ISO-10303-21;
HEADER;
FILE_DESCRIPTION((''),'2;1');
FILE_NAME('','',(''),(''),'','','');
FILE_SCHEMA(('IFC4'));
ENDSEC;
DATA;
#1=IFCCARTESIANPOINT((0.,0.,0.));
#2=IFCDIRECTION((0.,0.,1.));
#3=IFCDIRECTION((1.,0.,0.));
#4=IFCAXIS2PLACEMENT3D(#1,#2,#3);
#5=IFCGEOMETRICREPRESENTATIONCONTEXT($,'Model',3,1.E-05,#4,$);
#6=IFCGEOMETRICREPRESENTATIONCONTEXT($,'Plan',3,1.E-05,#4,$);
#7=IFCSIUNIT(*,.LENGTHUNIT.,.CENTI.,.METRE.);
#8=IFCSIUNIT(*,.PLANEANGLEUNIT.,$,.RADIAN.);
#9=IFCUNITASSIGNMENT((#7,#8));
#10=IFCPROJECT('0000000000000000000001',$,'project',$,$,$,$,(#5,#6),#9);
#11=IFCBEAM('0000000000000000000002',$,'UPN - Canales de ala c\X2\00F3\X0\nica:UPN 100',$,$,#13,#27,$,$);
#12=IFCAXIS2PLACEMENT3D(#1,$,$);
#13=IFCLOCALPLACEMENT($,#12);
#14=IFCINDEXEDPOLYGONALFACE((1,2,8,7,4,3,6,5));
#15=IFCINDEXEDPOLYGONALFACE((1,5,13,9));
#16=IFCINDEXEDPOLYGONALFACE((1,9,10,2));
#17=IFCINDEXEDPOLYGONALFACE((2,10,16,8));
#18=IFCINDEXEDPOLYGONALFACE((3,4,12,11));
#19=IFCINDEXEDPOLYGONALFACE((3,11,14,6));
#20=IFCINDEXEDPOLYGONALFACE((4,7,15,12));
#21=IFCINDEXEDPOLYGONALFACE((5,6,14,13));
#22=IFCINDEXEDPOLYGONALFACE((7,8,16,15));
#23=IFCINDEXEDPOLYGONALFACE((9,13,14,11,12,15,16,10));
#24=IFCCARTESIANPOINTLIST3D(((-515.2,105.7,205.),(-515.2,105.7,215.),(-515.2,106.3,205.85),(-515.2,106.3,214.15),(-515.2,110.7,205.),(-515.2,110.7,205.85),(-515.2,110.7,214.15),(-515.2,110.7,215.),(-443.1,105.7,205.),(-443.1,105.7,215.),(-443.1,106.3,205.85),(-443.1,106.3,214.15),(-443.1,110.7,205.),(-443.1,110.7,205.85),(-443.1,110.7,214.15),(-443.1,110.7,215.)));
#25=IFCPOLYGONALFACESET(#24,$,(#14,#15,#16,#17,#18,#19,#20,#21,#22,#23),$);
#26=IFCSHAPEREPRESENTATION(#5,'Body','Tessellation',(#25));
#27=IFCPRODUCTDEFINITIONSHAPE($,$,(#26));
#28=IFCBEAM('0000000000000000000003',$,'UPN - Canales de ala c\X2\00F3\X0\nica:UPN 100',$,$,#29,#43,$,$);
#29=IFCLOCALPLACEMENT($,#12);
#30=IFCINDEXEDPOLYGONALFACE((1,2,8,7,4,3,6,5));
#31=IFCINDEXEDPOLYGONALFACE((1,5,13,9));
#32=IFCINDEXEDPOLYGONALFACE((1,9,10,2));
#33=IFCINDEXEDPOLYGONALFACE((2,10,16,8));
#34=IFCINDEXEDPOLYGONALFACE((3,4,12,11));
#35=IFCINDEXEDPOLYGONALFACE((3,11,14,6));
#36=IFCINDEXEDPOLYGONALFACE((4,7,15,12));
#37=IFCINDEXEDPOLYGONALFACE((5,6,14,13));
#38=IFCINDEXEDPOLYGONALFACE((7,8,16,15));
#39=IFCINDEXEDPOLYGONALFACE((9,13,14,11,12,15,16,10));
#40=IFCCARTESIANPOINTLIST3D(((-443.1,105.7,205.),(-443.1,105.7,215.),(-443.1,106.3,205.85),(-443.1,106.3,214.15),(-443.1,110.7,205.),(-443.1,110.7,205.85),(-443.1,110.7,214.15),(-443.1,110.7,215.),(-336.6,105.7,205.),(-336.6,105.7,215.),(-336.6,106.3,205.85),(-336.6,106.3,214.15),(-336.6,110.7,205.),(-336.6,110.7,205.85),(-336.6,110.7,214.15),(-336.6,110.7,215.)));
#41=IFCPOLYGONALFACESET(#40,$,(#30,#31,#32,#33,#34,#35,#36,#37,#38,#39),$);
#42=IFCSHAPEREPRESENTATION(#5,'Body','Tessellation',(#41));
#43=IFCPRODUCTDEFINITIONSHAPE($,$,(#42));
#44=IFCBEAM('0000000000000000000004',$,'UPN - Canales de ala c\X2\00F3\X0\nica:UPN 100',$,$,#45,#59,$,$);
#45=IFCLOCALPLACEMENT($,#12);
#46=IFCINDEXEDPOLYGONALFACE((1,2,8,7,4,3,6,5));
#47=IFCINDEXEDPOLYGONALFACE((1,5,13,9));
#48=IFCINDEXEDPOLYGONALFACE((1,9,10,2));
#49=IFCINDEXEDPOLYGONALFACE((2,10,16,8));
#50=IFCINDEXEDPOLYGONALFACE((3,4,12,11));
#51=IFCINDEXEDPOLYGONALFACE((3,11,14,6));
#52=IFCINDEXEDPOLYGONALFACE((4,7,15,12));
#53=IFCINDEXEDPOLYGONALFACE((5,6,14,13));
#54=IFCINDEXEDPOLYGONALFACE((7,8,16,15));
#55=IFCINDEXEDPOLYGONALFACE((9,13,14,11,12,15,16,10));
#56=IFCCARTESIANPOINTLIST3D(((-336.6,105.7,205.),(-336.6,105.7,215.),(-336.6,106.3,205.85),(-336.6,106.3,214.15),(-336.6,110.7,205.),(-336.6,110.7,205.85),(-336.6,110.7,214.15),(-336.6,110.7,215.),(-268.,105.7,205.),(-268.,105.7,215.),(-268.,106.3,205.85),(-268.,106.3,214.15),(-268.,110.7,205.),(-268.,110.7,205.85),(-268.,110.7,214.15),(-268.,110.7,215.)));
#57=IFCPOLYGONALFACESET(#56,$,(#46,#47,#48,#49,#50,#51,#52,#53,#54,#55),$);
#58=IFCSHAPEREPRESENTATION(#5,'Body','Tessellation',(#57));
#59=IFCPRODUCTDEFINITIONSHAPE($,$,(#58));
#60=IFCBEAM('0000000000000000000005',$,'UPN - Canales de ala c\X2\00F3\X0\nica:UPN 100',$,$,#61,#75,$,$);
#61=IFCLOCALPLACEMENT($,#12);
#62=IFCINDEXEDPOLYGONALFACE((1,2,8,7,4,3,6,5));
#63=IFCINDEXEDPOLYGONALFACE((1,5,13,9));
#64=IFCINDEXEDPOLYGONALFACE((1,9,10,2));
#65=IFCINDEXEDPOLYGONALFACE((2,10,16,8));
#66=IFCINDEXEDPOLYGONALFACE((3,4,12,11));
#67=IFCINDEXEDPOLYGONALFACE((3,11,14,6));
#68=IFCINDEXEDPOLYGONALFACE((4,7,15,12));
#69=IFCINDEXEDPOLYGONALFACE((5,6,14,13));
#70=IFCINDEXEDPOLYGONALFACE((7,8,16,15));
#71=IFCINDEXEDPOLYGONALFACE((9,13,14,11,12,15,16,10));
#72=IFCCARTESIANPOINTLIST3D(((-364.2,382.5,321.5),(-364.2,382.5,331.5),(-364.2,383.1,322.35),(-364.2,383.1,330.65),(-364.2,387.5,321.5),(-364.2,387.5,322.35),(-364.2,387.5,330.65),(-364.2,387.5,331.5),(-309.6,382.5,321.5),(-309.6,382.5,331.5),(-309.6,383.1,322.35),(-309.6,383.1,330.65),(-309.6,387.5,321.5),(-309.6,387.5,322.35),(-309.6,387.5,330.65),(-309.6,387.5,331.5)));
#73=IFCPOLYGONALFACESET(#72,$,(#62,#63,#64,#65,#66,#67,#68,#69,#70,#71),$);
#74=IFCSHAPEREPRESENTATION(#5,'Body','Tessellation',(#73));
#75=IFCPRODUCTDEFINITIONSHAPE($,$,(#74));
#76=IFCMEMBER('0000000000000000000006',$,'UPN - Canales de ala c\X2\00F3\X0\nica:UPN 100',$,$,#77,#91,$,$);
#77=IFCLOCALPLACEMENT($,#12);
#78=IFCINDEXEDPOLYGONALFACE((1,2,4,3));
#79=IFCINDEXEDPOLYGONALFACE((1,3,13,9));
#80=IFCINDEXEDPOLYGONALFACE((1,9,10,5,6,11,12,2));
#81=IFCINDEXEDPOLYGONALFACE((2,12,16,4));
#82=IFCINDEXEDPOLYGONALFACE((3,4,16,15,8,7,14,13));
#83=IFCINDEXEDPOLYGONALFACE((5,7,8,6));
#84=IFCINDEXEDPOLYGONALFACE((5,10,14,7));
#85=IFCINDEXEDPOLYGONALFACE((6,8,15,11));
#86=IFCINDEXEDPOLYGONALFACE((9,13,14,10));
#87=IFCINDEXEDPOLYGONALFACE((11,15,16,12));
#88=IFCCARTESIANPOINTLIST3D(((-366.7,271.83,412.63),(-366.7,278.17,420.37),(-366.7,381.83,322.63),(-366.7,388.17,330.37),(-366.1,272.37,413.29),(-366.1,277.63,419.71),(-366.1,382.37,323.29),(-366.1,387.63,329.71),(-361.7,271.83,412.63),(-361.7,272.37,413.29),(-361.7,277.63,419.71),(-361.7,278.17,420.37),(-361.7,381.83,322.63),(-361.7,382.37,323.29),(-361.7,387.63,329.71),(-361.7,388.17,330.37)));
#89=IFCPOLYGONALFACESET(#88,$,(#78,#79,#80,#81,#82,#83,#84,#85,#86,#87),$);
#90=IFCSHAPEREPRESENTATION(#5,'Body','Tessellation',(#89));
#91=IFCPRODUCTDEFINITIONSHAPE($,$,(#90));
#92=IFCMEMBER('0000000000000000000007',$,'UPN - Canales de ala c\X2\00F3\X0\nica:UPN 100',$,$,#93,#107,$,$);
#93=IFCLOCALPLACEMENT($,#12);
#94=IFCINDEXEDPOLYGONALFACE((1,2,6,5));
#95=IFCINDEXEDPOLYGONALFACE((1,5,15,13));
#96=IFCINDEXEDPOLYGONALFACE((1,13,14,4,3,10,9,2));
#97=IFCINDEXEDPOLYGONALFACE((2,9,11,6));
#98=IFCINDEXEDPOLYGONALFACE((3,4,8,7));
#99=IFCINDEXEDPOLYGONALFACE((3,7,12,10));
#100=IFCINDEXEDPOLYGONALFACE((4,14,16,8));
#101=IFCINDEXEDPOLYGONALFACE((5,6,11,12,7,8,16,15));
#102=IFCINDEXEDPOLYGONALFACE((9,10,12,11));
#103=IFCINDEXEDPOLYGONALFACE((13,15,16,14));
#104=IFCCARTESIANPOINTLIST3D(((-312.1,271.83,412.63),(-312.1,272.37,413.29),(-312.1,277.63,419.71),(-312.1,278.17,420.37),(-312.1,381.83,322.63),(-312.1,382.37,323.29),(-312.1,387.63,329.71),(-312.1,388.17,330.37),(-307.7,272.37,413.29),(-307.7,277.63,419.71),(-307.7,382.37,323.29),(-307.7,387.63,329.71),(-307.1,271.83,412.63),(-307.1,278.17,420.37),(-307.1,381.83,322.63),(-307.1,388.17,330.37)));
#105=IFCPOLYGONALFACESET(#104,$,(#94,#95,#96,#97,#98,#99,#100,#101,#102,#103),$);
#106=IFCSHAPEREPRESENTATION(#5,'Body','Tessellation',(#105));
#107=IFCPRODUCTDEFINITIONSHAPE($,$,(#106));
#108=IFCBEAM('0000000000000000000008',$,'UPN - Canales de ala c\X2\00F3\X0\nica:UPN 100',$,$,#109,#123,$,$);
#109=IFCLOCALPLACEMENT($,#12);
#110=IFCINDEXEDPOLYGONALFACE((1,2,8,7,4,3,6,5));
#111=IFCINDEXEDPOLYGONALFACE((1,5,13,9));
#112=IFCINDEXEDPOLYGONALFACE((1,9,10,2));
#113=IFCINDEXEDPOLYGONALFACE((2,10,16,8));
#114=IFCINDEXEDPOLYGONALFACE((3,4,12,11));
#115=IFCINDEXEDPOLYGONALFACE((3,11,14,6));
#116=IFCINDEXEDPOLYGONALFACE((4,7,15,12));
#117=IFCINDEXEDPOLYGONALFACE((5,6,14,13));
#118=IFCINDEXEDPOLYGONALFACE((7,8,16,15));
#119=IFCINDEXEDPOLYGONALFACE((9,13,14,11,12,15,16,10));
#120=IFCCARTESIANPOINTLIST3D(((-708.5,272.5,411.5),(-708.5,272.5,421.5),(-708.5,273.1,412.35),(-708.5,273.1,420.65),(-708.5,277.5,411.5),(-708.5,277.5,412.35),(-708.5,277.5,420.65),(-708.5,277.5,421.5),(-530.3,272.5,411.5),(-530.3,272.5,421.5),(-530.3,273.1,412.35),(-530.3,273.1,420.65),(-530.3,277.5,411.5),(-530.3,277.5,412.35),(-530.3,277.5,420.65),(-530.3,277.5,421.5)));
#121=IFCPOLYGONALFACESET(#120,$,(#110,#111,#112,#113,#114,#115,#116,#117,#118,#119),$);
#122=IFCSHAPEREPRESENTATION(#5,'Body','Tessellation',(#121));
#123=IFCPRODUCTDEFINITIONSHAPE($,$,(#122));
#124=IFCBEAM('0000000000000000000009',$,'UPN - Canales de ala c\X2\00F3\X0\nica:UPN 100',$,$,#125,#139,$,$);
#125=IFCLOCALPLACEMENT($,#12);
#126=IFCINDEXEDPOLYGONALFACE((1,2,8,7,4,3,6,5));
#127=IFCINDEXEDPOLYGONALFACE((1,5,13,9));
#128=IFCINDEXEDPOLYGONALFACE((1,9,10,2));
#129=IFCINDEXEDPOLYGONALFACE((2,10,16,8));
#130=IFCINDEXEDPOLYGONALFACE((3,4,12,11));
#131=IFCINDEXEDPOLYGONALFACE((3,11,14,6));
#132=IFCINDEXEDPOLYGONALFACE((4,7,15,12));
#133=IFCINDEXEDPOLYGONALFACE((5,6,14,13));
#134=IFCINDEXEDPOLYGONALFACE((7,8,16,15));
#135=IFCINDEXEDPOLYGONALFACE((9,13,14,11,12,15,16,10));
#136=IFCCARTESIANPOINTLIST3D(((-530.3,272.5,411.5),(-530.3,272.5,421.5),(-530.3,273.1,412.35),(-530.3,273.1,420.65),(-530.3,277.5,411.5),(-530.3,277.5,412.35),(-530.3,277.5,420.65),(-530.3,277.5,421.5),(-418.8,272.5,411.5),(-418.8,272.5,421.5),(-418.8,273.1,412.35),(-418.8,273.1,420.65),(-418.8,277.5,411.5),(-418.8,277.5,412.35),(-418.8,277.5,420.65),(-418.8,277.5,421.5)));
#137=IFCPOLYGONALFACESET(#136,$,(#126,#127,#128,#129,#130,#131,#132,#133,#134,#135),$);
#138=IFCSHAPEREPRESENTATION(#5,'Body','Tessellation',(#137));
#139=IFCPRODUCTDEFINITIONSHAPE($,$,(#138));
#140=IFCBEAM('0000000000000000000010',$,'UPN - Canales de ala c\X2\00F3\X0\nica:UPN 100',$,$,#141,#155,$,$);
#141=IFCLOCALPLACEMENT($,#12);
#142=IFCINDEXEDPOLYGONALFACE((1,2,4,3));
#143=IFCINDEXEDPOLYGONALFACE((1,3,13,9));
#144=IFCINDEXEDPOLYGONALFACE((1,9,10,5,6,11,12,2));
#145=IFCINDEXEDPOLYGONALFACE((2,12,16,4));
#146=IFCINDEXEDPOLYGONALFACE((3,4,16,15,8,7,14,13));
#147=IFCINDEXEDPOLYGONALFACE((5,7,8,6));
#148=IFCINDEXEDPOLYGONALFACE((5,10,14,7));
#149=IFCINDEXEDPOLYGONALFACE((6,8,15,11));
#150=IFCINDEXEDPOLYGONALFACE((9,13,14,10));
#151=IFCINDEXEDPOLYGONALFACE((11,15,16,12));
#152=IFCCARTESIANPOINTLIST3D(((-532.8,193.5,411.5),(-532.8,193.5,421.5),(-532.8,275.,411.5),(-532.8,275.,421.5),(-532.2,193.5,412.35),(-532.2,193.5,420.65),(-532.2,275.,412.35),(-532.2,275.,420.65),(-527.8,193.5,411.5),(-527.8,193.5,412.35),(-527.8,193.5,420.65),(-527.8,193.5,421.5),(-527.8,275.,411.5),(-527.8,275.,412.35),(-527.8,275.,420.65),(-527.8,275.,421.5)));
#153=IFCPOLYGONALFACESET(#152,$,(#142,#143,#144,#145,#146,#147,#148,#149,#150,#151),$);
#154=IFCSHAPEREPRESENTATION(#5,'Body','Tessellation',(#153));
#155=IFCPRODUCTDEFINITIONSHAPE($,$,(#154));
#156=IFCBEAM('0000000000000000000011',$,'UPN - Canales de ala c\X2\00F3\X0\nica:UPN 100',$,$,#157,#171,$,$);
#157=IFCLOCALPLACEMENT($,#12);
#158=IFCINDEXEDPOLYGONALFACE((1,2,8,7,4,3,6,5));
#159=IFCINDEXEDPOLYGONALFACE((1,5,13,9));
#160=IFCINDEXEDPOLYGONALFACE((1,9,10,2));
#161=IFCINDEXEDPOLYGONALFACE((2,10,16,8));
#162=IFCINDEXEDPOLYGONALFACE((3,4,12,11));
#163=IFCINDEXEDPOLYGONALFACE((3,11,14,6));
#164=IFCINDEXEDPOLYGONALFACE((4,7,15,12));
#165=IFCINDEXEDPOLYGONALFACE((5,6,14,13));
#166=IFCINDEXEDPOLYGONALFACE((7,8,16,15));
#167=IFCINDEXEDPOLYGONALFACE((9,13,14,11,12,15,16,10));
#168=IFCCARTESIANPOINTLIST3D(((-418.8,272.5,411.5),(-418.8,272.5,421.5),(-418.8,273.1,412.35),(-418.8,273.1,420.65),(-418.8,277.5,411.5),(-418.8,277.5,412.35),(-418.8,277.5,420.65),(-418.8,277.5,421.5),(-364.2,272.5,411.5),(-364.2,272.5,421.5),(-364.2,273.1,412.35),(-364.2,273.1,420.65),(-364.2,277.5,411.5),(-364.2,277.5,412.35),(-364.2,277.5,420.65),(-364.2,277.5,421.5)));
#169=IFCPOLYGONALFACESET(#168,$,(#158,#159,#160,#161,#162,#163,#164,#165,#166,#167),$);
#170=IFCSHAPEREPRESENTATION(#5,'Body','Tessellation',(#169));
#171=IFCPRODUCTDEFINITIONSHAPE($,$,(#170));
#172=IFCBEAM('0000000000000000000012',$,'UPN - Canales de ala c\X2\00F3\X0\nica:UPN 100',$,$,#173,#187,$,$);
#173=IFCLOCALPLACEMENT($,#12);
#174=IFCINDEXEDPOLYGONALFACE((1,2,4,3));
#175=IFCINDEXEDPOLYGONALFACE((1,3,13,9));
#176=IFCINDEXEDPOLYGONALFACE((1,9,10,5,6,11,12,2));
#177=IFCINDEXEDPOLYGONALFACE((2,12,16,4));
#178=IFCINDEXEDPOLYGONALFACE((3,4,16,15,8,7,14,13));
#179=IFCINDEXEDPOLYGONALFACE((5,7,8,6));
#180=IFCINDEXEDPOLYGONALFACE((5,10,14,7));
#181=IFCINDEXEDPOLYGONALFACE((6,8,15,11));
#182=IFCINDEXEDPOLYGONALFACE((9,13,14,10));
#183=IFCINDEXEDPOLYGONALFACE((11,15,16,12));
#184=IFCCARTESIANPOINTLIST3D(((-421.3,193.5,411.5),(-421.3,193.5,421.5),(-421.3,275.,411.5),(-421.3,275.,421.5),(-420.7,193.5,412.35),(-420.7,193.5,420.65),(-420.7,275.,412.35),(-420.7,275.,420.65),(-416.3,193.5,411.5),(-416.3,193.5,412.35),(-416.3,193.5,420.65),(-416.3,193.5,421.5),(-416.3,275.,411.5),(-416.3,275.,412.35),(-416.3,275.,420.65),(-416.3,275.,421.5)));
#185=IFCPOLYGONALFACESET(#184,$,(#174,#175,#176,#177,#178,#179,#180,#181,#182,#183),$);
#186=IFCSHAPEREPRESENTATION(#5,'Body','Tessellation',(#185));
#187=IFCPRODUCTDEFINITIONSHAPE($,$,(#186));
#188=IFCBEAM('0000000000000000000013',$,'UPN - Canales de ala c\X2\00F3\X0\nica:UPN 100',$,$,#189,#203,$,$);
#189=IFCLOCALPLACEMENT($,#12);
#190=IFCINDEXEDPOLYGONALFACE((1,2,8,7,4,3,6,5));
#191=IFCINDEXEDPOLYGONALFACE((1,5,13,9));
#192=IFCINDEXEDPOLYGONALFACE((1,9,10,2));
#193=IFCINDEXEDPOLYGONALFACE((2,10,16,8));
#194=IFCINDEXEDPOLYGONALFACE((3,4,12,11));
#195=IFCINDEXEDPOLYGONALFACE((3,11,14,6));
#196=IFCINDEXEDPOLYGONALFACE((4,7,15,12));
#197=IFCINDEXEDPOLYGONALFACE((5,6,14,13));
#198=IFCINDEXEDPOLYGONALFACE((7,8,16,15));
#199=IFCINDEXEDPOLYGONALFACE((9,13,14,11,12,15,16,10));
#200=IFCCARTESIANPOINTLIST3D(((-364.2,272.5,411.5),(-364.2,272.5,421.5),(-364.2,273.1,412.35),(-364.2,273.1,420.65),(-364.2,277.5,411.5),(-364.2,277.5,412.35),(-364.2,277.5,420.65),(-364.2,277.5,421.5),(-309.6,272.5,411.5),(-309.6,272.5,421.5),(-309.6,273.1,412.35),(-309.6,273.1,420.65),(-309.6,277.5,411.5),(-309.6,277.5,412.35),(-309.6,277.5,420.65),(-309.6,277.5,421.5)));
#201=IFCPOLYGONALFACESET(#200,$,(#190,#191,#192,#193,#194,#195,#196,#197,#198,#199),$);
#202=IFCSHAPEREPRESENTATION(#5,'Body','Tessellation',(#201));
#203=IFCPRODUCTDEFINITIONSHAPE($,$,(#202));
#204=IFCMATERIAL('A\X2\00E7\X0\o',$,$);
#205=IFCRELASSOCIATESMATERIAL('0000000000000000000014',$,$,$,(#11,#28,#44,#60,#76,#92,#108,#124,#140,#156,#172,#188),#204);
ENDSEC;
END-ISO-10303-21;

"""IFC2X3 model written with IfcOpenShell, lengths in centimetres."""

from ifc_helpers import new_model, si_unit, frame, origin_with_axes, origin_2d_with_axis, place, context, project, u_section, extrude, material, element, save


model = new_model("IFC2X3")

# Units and contexts
model_context = context("Model", 3, precision=1e-05, world=origin_with_axes())
plan_context = context("Plan", 3, precision=1e-05, world=origin_with_axes())
ifc_project = project(units=[si_unit("LENGTHUNIT", "METRE", prefix="CENTI"), si_unit("PLANEANGLEUNIT", "RADIAN")], contexts=[model_context, plan_context])

# Shared definitions
ifc_material = material(Name="Aço")

# Beams
beam_1_placement = place(None, frame((-443.1, 108.2, 210.0), z_axis=(-1.0, 0.0, 0.0), x_axis=(0.0, 1.0, 0.0)))
element("IfcBeam", 1, at=beam_1_placement, material=ifc_material, Name="UPN - Canales de ala cónica:UPN 100", context=model_context, shape_type="SweptSolid", body=[
    extrude(u_section(Depth=10.0, FlangeWidth=5.0, WebThickness=0.6, FlangeThickness=0.85, FilletRadius=0.0, EdgeRadius=0.0, FlangeSlope=0.0, CentreOfGravityInX=0.0, at=origin_2d_with_axis()), origin_with_axes(), (0.0, 0.0, 1.0), 72.1),
])
beam_2_placement = place(None, frame((-336.6, 108.2, 210.0), z_axis=(-1.0, 0.0, 0.0), x_axis=(0.0, 1.0, 0.0)))
element("IfcBeam", 2, at=beam_2_placement, material=ifc_material, Name="UPN - Canales de ala cónica:UPN 100", context=model_context, shape_type="SweptSolid", body=[
    extrude(u_section(Depth=10.0, FlangeWidth=5.0, WebThickness=0.6, FlangeThickness=0.85, FilletRadius=0.0, EdgeRadius=0.0, FlangeSlope=0.0, CentreOfGravityInX=0.0, at=origin_2d_with_axis()), origin_with_axes(), (0.0, 0.0, 1.0), 106.5),
])
beam_3_placement = place(None, frame((-268.0, 108.2, 210.0), z_axis=(-1.0, 0.0, 0.0), x_axis=(0.0, 1.0, 0.0)))
element("IfcBeam", 3, at=beam_3_placement, material=ifc_material, Name="UPN - Canales de ala cónica:UPN 100", context=model_context, shape_type="SweptSolid", body=[
    extrude(u_section(Depth=10.0, FlangeWidth=5.0, WebThickness=0.6, FlangeThickness=0.85, FilletRadius=0.0, EdgeRadius=0.0, FlangeSlope=0.0, CentreOfGravityInX=0.0, at=origin_2d_with_axis()), origin_with_axes(), (0.0, 0.0, 1.0), 68.6),
])
beam_4_placement = place(None, frame((-309.6, 385.0, 326.5), z_axis=(-1.0, 0.0, 0.0), x_axis=(0.0, 1.0, 0.0)))
element("IfcBeam", 4, at=beam_4_placement, material=ifc_material, Name="UPN - Canales de ala cónica:UPN 100", context=model_context, shape_type="SweptSolid", body=[
    extrude(u_section(Depth=10.0, FlangeWidth=5.0, WebThickness=0.6, FlangeThickness=0.85, FilletRadius=0.0, EdgeRadius=0.0, FlangeSlope=0.0, CentreOfGravityInX=0.0, at=origin_2d_with_axis()), origin_with_axes(), (0.0, 0.0, 1.0), 54.6),
])

# Members
for number, where, z_axis, x_axis, name in (
    (5, (-364.2, 385.0, 326.5), (0.0, -0.773957, 0.633238), (1.0, 0.0, 0.0), "UPN - Canales de ala cónica:UPN 100"),
    (6, (-309.6, 385.0, 326.5), (0.0, -0.773957, 0.633238), (-1.0, 0.0, 0.0), "UPN - Canales de ala cónica:UPN 100"),
):
    element("IfcMember", number, at=place(None, frame(where, z_axis=z_axis, x_axis=x_axis)), material=ifc_material, Name=name, context=model_context, shape_type="SweptSolid", body=[
        extrude(u_section(Depth=10.0, FlangeWidth=5.0, WebThickness=0.6, FlangeThickness=0.85, FilletRadius=0.0, EdgeRadius=0.0, FlangeSlope=0.0, CentreOfGravityInX=0.0, at=origin_2d_with_axis()), origin_with_axes(), (0.0, 0.0, 1.0), 142.13),
    ])

# Beams
beam_5_placement = place(None, frame((-530.3, 275.0, 416.5), z_axis=(-1.0, 0.0, 0.0), x_axis=(0.0, 1.0, 0.0)))
element("IfcBeam", 7, at=beam_5_placement, material=ifc_material, Name="UPN - Canales de ala cónica:UPN 100", context=model_context, shape_type="SweptSolid", body=[
    extrude(u_section(Depth=10.0, FlangeWidth=5.0, WebThickness=0.6, FlangeThickness=0.85, FilletRadius=0.0, EdgeRadius=0.0, FlangeSlope=0.0, CentreOfGravityInX=0.0, at=origin_2d_with_axis()), origin_with_axes(), (0.0, 0.0, 1.0), 178.2),
])
beam_6_placement = place(None, frame((-418.8, 275.0, 416.5), z_axis=(-1.0, 0.0, 0.0), x_axis=(0.0, 1.0, 0.0)))
element("IfcBeam", 8, at=beam_6_placement, material=ifc_material, Name="UPN - Canales de ala cónica:UPN 100", context=model_context, shape_type="SweptSolid", body=[
    extrude(u_section(Depth=10.0, FlangeWidth=5.0, WebThickness=0.6, FlangeThickness=0.85, FilletRadius=0.0, EdgeRadius=0.0, FlangeSlope=0.0, CentreOfGravityInX=0.0, at=origin_2d_with_axis()), origin_with_axes(), (0.0, 0.0, 1.0), 111.5),
])
beam_7_placement = place(None, frame((-530.3, 193.5, 416.5), z_axis=(0.0, 1.0, 0.0), x_axis=(1.0, 0.0, 0.0)))
element("IfcBeam", 9, at=beam_7_placement, material=ifc_material, Name="UPN - Canales de ala cónica:UPN 100", context=model_context, shape_type="SweptSolid", body=[
    extrude(u_section(Depth=10.0, FlangeWidth=5.0, WebThickness=0.6, FlangeThickness=0.85, FilletRadius=0.0, EdgeRadius=0.0, FlangeSlope=0.0, CentreOfGravityInX=0.0, at=origin_2d_with_axis()), origin_with_axes(), (0.0, 0.0, 1.0), 81.5),
])
beam_8_placement = place(None, frame((-364.2, 275.0, 416.5), z_axis=(-1.0, 0.0, 0.0), x_axis=(0.0, 1.0, 0.0)))
element("IfcBeam", 10, at=beam_8_placement, material=ifc_material, Name="UPN - Canales de ala cónica:UPN 100", context=model_context, shape_type="SweptSolid", body=[
    extrude(u_section(Depth=10.0, FlangeWidth=5.0, WebThickness=0.6, FlangeThickness=0.85, FilletRadius=0.0, EdgeRadius=0.0, FlangeSlope=0.0, CentreOfGravityInX=0.0, at=origin_2d_with_axis()), origin_with_axes(), (0.0, 0.0, 1.0), 54.6),
])
beam_9_placement = place(None, frame((-418.8, 193.5, 416.5), z_axis=(0.0, 1.0, 0.0), x_axis=(1.0, 0.0, 0.0)))
element("IfcBeam", 11, at=beam_9_placement, material=ifc_material, Name="UPN - Canales de ala cónica:UPN 100", context=model_context, shape_type="SweptSolid", body=[
    extrude(u_section(Depth=10.0, FlangeWidth=5.0, WebThickness=0.6, FlangeThickness=0.85, FilletRadius=0.0, EdgeRadius=0.0, FlangeSlope=0.0, CentreOfGravityInX=0.0, at=origin_2d_with_axis()), origin_with_axes(), (0.0, 0.0, 1.0), 81.5),
])
beam_10_placement = place(None, frame((-309.6, 275.0, 416.5), z_axis=(-1.0, 0.0, 0.0), x_axis=(0.0, 1.0, 0.0)))
element("IfcBeam", 12, at=beam_10_placement, material=ifc_material, Name="UPN - Canales de ala cónica:UPN 100", context=model_context, shape_type="SweptSolid", body=[
    extrude(u_section(Depth=10.0, FlangeWidth=5.0, WebThickness=0.6, FlangeThickness=0.85, FilletRadius=0.0, EdgeRadius=0.0, FlangeSlope=0.0, CentreOfGravityInX=0.0, at=origin_2d_with_axis()), origin_with_axes(), (0.0, 0.0, 1.0), 54.6),
])

save(model, "model.ifc")
